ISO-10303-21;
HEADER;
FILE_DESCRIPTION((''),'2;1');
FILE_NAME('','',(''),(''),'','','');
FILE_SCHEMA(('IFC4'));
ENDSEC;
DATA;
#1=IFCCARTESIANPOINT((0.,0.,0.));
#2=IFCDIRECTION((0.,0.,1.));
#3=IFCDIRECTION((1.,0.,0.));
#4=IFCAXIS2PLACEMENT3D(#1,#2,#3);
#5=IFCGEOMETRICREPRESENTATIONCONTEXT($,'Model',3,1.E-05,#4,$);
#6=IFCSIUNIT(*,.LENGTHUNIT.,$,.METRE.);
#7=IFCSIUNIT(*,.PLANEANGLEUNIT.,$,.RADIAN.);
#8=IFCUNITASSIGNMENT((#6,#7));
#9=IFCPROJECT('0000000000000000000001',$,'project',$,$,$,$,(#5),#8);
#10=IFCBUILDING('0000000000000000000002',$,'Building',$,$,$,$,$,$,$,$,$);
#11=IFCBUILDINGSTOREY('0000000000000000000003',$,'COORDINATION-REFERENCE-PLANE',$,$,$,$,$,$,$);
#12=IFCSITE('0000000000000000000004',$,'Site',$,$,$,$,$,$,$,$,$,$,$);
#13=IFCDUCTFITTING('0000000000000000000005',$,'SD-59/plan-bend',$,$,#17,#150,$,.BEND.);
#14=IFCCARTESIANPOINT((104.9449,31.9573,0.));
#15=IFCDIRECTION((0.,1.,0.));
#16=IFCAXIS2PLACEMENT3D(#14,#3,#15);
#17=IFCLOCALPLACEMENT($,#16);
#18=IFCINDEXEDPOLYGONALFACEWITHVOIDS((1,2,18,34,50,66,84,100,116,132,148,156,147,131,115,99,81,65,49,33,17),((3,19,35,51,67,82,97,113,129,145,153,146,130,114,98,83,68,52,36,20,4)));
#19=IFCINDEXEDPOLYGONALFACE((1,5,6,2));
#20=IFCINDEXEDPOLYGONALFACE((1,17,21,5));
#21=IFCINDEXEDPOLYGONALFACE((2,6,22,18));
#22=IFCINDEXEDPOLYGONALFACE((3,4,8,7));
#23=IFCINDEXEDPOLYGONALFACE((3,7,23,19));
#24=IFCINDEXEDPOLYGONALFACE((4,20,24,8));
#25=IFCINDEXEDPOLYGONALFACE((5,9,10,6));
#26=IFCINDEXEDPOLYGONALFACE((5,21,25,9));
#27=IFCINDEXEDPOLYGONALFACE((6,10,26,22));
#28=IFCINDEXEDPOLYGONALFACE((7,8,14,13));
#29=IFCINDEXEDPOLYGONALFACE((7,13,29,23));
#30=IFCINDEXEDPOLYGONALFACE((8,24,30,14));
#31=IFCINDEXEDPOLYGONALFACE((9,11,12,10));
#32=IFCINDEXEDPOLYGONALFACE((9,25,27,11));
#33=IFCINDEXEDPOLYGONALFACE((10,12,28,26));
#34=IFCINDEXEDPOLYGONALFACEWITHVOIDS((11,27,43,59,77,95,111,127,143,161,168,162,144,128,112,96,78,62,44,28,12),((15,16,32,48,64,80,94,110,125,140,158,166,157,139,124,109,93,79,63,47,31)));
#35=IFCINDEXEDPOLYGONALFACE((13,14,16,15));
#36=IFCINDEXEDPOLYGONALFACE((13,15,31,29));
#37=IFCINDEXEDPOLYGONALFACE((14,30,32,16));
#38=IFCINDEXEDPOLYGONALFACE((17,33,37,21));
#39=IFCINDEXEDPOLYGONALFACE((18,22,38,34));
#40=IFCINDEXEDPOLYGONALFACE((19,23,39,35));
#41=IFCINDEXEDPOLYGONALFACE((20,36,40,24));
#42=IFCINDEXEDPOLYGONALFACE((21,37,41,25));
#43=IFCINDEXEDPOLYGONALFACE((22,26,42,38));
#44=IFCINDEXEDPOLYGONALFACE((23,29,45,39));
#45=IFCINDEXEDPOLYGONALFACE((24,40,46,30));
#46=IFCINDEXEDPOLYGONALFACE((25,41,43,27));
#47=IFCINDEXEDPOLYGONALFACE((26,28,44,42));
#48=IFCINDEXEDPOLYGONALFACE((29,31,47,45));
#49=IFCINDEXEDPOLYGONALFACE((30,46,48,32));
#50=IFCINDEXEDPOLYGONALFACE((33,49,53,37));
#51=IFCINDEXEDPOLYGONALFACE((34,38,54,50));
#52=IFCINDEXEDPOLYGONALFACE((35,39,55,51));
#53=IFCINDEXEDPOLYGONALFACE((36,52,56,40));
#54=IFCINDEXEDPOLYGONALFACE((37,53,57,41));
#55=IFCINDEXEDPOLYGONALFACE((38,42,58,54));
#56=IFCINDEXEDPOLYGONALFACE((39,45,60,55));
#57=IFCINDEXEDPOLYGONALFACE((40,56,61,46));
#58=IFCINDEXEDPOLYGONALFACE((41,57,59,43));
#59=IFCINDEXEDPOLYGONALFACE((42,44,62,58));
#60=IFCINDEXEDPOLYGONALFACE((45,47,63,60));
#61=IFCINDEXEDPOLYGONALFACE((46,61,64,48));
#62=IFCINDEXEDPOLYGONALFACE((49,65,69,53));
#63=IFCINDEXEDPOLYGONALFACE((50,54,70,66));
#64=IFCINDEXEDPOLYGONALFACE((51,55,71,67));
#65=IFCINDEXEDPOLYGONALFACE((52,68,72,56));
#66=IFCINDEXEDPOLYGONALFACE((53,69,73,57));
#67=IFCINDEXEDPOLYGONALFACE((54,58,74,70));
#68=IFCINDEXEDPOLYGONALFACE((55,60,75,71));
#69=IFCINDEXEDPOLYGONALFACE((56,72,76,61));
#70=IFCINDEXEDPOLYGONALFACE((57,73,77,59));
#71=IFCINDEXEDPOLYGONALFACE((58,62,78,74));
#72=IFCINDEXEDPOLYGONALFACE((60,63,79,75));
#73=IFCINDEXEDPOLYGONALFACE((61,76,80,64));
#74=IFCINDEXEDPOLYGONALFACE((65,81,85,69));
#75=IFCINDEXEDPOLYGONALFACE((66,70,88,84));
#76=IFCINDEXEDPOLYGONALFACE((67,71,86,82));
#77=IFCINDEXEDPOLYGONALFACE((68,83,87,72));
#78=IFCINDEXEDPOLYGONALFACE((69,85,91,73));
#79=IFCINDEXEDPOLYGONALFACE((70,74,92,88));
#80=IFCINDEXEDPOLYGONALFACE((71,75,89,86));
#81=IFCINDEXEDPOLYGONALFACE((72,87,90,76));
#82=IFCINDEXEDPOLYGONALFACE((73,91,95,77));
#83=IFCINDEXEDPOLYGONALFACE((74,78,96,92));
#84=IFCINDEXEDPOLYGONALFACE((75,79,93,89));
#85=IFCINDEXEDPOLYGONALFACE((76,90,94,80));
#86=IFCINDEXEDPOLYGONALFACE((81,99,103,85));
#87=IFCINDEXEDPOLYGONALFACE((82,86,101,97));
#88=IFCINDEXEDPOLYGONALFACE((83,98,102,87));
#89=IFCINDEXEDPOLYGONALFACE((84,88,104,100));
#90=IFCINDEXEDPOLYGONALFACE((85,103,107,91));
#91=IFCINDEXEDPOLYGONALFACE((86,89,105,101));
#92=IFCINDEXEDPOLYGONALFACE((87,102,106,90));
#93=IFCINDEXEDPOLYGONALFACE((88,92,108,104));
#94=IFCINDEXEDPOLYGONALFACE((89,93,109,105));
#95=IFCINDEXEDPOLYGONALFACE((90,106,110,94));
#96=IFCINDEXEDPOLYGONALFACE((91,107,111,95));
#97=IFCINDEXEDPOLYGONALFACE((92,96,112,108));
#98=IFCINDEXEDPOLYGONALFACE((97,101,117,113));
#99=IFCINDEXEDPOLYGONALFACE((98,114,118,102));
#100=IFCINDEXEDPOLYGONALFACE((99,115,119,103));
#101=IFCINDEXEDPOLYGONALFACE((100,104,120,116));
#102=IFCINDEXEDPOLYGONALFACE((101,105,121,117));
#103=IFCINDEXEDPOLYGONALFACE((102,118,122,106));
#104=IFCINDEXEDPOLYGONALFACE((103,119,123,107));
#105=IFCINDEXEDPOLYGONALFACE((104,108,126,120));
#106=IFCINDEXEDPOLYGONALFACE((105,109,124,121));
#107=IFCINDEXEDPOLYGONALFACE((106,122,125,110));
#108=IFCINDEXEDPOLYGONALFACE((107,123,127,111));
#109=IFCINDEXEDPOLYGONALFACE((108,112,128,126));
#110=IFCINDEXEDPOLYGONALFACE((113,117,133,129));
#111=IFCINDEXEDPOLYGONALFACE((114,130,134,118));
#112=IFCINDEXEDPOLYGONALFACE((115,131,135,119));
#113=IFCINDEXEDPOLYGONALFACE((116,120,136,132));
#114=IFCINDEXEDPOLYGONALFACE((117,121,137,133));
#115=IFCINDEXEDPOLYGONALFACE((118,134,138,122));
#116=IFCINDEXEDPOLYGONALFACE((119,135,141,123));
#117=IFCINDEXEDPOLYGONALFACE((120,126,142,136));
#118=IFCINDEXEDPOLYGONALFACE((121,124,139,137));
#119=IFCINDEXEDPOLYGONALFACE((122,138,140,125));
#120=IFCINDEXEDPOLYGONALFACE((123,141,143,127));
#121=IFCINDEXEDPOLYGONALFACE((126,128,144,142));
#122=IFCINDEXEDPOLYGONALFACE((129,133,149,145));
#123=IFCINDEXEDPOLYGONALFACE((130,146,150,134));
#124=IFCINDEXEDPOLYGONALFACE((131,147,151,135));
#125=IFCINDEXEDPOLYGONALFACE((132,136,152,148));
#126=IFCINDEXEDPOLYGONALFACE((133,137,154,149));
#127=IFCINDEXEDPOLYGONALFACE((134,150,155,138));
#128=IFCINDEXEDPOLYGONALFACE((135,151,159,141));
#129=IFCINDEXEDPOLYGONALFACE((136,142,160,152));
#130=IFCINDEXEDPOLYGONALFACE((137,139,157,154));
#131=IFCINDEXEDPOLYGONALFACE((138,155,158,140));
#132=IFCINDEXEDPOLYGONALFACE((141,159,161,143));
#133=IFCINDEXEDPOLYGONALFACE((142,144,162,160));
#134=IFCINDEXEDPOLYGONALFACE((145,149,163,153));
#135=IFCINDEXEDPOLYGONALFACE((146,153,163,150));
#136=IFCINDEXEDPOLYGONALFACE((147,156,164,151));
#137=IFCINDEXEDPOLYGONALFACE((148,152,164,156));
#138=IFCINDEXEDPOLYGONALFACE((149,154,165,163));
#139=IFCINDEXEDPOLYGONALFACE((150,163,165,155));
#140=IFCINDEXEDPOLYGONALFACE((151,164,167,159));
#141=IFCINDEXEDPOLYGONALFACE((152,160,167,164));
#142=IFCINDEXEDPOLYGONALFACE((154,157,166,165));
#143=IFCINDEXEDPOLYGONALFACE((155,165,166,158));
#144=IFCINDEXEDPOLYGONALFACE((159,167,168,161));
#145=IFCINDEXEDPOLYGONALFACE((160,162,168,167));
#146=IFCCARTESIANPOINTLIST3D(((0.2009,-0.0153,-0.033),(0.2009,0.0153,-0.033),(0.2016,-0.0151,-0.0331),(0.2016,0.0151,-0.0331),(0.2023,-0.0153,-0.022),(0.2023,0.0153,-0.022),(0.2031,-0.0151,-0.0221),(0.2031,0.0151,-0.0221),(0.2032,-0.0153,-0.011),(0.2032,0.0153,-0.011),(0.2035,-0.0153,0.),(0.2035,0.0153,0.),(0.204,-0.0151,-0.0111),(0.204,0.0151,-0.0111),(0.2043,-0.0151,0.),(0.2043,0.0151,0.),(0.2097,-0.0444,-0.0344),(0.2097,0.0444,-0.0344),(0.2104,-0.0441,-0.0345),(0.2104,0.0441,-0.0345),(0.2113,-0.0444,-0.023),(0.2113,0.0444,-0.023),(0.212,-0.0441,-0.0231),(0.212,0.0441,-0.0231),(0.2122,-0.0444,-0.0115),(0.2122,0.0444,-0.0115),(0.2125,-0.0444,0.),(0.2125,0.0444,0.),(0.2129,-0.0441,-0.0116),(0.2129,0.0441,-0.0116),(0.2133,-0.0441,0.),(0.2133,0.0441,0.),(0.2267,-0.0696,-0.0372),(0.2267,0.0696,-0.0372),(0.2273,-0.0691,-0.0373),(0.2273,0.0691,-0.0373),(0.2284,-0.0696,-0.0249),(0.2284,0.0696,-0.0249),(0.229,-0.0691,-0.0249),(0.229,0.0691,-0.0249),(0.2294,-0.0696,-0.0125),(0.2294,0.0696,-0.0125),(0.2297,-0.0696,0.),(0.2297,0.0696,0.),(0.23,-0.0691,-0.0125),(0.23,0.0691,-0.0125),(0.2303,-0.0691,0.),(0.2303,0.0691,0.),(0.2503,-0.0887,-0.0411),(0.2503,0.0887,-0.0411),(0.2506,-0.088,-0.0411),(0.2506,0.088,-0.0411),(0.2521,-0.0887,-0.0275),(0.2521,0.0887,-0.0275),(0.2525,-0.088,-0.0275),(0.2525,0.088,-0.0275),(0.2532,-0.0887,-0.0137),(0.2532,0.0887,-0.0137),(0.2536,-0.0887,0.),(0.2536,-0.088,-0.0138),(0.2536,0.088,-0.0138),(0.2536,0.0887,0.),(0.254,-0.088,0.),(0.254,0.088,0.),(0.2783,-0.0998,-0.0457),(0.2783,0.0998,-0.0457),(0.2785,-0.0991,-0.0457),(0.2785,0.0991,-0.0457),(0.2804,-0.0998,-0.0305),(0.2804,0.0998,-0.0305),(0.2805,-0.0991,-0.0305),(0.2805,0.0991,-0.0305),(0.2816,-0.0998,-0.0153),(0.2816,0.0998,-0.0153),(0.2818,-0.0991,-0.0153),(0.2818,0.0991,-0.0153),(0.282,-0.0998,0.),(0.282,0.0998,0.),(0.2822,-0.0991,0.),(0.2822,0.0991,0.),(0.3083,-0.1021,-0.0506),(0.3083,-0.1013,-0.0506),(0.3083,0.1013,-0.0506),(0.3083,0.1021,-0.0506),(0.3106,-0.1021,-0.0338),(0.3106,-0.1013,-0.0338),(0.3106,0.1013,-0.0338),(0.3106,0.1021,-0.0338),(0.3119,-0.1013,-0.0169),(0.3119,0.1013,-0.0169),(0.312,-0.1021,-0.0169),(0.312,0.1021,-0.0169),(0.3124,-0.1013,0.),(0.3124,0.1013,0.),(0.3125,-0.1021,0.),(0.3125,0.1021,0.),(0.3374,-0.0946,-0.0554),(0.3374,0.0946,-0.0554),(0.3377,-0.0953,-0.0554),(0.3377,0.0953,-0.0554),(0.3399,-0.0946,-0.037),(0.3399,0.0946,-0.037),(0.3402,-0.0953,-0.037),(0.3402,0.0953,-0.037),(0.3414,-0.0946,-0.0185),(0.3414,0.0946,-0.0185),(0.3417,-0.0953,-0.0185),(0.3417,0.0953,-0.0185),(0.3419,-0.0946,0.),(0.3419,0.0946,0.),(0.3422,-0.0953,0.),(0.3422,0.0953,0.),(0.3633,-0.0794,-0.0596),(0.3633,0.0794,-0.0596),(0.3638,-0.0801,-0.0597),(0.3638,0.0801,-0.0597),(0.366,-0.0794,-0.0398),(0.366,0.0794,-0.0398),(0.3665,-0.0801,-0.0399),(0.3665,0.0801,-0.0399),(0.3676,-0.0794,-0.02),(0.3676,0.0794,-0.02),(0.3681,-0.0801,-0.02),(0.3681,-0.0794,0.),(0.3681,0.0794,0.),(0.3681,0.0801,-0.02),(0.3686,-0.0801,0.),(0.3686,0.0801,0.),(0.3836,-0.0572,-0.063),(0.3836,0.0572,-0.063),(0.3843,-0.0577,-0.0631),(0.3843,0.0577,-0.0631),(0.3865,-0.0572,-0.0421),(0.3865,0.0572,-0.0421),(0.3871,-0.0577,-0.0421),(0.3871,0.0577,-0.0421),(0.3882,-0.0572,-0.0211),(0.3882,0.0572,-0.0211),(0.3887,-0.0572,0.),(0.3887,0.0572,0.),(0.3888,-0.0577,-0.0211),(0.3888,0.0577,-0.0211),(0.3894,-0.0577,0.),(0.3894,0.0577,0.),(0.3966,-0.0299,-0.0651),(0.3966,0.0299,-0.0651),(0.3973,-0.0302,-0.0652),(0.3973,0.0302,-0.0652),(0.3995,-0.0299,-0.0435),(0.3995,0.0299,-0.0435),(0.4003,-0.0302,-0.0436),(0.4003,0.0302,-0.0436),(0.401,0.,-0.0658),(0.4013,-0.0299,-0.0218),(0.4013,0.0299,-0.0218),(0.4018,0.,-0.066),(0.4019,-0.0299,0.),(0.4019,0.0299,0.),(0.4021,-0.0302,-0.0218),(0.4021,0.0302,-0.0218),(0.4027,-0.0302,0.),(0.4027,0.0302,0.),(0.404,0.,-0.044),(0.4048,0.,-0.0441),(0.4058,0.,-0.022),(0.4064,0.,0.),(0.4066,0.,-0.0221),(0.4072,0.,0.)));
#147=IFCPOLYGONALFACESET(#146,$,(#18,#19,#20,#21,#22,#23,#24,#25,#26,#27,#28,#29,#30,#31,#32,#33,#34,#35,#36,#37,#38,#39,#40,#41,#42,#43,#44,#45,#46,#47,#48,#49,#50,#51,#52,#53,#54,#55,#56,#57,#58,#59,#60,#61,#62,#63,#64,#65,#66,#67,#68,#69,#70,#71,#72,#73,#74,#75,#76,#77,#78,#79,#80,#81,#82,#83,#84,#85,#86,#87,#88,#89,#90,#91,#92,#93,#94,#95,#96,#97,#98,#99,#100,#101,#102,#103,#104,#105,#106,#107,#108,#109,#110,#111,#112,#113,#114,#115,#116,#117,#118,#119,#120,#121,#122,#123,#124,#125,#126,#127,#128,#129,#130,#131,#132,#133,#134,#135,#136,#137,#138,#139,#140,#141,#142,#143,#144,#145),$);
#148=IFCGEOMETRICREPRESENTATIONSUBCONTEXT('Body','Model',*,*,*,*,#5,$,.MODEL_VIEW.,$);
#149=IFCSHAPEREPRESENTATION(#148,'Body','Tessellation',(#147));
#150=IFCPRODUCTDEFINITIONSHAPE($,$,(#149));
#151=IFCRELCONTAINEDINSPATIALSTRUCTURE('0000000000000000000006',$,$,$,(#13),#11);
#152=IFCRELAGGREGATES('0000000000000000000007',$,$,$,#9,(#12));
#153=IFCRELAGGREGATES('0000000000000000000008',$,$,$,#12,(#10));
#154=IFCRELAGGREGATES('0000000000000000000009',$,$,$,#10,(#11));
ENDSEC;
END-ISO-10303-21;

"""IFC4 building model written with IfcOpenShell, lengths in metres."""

from ifc_helpers import new_model, entity, si_unit, frame, origin_with_axes, place, context, subcontext, project, spatial, element, save


model = new_model("IFC4")

# Units and contexts
model_context = context("Model", 3, precision=1e-05, world=origin_with_axes())
body_context_1 = subcontext(model_context, "Body", "Model", "MODEL_VIEW")
ifc_project = project(units=[si_unit("LENGTHUNIT", "METRE"), si_unit("PLANEANGLEUNIT", "RADIAN")], contexts=[model_context])

# Site, building, storey
site = spatial("IfcSite", under=ifc_project, Name="Site")
building = spatial("IfcBuilding", under=site, Name="Building")
storey = spatial("IfcBuildingStorey", under=building, Name="COORDINATION-REFERENCE-PLANE")

# Duct fitting
duct_fitting_1_placement = place(None, frame((104.9449, 31.9573, 0.0), z_axis=(1.0, 0.0, 0.0), x_axis=(0.0, 1.0, 0.0)))
element("IfcDuctFitting", 1, at=duct_fitting_1_placement, inside=storey, Name="SD-59/plan-bend", PredefinedType="BEND", context=body_context_1, shape_type="SweptSolid", body=[
    entity("IfcRevolvedAreaSolid", entity("IfcCircleHollowProfileDef", "AREA", None, entity("IfcAxis2Placement2D", entity("IfcCartesianPoint", [0.3048, 0.0])), 0.1024, 0.0008), entity("IfcAxis2Placement3D", entity("IfcCartesianPoint", [0.0, 0.0, 0.0]), entity("IfcDirection", [0.0, 0.0, 1.0]), entity("IfcDirection", [1.0, 0.0, 0.0])), entity("IfcAxis1Placement", entity("IfcCartesianPoint", [0.0, 0.0, 0.0]), entity("IfcDirection", [0.0, 1.0, 0.0])), 0.162681),
])

save(model, "model.ifc")
